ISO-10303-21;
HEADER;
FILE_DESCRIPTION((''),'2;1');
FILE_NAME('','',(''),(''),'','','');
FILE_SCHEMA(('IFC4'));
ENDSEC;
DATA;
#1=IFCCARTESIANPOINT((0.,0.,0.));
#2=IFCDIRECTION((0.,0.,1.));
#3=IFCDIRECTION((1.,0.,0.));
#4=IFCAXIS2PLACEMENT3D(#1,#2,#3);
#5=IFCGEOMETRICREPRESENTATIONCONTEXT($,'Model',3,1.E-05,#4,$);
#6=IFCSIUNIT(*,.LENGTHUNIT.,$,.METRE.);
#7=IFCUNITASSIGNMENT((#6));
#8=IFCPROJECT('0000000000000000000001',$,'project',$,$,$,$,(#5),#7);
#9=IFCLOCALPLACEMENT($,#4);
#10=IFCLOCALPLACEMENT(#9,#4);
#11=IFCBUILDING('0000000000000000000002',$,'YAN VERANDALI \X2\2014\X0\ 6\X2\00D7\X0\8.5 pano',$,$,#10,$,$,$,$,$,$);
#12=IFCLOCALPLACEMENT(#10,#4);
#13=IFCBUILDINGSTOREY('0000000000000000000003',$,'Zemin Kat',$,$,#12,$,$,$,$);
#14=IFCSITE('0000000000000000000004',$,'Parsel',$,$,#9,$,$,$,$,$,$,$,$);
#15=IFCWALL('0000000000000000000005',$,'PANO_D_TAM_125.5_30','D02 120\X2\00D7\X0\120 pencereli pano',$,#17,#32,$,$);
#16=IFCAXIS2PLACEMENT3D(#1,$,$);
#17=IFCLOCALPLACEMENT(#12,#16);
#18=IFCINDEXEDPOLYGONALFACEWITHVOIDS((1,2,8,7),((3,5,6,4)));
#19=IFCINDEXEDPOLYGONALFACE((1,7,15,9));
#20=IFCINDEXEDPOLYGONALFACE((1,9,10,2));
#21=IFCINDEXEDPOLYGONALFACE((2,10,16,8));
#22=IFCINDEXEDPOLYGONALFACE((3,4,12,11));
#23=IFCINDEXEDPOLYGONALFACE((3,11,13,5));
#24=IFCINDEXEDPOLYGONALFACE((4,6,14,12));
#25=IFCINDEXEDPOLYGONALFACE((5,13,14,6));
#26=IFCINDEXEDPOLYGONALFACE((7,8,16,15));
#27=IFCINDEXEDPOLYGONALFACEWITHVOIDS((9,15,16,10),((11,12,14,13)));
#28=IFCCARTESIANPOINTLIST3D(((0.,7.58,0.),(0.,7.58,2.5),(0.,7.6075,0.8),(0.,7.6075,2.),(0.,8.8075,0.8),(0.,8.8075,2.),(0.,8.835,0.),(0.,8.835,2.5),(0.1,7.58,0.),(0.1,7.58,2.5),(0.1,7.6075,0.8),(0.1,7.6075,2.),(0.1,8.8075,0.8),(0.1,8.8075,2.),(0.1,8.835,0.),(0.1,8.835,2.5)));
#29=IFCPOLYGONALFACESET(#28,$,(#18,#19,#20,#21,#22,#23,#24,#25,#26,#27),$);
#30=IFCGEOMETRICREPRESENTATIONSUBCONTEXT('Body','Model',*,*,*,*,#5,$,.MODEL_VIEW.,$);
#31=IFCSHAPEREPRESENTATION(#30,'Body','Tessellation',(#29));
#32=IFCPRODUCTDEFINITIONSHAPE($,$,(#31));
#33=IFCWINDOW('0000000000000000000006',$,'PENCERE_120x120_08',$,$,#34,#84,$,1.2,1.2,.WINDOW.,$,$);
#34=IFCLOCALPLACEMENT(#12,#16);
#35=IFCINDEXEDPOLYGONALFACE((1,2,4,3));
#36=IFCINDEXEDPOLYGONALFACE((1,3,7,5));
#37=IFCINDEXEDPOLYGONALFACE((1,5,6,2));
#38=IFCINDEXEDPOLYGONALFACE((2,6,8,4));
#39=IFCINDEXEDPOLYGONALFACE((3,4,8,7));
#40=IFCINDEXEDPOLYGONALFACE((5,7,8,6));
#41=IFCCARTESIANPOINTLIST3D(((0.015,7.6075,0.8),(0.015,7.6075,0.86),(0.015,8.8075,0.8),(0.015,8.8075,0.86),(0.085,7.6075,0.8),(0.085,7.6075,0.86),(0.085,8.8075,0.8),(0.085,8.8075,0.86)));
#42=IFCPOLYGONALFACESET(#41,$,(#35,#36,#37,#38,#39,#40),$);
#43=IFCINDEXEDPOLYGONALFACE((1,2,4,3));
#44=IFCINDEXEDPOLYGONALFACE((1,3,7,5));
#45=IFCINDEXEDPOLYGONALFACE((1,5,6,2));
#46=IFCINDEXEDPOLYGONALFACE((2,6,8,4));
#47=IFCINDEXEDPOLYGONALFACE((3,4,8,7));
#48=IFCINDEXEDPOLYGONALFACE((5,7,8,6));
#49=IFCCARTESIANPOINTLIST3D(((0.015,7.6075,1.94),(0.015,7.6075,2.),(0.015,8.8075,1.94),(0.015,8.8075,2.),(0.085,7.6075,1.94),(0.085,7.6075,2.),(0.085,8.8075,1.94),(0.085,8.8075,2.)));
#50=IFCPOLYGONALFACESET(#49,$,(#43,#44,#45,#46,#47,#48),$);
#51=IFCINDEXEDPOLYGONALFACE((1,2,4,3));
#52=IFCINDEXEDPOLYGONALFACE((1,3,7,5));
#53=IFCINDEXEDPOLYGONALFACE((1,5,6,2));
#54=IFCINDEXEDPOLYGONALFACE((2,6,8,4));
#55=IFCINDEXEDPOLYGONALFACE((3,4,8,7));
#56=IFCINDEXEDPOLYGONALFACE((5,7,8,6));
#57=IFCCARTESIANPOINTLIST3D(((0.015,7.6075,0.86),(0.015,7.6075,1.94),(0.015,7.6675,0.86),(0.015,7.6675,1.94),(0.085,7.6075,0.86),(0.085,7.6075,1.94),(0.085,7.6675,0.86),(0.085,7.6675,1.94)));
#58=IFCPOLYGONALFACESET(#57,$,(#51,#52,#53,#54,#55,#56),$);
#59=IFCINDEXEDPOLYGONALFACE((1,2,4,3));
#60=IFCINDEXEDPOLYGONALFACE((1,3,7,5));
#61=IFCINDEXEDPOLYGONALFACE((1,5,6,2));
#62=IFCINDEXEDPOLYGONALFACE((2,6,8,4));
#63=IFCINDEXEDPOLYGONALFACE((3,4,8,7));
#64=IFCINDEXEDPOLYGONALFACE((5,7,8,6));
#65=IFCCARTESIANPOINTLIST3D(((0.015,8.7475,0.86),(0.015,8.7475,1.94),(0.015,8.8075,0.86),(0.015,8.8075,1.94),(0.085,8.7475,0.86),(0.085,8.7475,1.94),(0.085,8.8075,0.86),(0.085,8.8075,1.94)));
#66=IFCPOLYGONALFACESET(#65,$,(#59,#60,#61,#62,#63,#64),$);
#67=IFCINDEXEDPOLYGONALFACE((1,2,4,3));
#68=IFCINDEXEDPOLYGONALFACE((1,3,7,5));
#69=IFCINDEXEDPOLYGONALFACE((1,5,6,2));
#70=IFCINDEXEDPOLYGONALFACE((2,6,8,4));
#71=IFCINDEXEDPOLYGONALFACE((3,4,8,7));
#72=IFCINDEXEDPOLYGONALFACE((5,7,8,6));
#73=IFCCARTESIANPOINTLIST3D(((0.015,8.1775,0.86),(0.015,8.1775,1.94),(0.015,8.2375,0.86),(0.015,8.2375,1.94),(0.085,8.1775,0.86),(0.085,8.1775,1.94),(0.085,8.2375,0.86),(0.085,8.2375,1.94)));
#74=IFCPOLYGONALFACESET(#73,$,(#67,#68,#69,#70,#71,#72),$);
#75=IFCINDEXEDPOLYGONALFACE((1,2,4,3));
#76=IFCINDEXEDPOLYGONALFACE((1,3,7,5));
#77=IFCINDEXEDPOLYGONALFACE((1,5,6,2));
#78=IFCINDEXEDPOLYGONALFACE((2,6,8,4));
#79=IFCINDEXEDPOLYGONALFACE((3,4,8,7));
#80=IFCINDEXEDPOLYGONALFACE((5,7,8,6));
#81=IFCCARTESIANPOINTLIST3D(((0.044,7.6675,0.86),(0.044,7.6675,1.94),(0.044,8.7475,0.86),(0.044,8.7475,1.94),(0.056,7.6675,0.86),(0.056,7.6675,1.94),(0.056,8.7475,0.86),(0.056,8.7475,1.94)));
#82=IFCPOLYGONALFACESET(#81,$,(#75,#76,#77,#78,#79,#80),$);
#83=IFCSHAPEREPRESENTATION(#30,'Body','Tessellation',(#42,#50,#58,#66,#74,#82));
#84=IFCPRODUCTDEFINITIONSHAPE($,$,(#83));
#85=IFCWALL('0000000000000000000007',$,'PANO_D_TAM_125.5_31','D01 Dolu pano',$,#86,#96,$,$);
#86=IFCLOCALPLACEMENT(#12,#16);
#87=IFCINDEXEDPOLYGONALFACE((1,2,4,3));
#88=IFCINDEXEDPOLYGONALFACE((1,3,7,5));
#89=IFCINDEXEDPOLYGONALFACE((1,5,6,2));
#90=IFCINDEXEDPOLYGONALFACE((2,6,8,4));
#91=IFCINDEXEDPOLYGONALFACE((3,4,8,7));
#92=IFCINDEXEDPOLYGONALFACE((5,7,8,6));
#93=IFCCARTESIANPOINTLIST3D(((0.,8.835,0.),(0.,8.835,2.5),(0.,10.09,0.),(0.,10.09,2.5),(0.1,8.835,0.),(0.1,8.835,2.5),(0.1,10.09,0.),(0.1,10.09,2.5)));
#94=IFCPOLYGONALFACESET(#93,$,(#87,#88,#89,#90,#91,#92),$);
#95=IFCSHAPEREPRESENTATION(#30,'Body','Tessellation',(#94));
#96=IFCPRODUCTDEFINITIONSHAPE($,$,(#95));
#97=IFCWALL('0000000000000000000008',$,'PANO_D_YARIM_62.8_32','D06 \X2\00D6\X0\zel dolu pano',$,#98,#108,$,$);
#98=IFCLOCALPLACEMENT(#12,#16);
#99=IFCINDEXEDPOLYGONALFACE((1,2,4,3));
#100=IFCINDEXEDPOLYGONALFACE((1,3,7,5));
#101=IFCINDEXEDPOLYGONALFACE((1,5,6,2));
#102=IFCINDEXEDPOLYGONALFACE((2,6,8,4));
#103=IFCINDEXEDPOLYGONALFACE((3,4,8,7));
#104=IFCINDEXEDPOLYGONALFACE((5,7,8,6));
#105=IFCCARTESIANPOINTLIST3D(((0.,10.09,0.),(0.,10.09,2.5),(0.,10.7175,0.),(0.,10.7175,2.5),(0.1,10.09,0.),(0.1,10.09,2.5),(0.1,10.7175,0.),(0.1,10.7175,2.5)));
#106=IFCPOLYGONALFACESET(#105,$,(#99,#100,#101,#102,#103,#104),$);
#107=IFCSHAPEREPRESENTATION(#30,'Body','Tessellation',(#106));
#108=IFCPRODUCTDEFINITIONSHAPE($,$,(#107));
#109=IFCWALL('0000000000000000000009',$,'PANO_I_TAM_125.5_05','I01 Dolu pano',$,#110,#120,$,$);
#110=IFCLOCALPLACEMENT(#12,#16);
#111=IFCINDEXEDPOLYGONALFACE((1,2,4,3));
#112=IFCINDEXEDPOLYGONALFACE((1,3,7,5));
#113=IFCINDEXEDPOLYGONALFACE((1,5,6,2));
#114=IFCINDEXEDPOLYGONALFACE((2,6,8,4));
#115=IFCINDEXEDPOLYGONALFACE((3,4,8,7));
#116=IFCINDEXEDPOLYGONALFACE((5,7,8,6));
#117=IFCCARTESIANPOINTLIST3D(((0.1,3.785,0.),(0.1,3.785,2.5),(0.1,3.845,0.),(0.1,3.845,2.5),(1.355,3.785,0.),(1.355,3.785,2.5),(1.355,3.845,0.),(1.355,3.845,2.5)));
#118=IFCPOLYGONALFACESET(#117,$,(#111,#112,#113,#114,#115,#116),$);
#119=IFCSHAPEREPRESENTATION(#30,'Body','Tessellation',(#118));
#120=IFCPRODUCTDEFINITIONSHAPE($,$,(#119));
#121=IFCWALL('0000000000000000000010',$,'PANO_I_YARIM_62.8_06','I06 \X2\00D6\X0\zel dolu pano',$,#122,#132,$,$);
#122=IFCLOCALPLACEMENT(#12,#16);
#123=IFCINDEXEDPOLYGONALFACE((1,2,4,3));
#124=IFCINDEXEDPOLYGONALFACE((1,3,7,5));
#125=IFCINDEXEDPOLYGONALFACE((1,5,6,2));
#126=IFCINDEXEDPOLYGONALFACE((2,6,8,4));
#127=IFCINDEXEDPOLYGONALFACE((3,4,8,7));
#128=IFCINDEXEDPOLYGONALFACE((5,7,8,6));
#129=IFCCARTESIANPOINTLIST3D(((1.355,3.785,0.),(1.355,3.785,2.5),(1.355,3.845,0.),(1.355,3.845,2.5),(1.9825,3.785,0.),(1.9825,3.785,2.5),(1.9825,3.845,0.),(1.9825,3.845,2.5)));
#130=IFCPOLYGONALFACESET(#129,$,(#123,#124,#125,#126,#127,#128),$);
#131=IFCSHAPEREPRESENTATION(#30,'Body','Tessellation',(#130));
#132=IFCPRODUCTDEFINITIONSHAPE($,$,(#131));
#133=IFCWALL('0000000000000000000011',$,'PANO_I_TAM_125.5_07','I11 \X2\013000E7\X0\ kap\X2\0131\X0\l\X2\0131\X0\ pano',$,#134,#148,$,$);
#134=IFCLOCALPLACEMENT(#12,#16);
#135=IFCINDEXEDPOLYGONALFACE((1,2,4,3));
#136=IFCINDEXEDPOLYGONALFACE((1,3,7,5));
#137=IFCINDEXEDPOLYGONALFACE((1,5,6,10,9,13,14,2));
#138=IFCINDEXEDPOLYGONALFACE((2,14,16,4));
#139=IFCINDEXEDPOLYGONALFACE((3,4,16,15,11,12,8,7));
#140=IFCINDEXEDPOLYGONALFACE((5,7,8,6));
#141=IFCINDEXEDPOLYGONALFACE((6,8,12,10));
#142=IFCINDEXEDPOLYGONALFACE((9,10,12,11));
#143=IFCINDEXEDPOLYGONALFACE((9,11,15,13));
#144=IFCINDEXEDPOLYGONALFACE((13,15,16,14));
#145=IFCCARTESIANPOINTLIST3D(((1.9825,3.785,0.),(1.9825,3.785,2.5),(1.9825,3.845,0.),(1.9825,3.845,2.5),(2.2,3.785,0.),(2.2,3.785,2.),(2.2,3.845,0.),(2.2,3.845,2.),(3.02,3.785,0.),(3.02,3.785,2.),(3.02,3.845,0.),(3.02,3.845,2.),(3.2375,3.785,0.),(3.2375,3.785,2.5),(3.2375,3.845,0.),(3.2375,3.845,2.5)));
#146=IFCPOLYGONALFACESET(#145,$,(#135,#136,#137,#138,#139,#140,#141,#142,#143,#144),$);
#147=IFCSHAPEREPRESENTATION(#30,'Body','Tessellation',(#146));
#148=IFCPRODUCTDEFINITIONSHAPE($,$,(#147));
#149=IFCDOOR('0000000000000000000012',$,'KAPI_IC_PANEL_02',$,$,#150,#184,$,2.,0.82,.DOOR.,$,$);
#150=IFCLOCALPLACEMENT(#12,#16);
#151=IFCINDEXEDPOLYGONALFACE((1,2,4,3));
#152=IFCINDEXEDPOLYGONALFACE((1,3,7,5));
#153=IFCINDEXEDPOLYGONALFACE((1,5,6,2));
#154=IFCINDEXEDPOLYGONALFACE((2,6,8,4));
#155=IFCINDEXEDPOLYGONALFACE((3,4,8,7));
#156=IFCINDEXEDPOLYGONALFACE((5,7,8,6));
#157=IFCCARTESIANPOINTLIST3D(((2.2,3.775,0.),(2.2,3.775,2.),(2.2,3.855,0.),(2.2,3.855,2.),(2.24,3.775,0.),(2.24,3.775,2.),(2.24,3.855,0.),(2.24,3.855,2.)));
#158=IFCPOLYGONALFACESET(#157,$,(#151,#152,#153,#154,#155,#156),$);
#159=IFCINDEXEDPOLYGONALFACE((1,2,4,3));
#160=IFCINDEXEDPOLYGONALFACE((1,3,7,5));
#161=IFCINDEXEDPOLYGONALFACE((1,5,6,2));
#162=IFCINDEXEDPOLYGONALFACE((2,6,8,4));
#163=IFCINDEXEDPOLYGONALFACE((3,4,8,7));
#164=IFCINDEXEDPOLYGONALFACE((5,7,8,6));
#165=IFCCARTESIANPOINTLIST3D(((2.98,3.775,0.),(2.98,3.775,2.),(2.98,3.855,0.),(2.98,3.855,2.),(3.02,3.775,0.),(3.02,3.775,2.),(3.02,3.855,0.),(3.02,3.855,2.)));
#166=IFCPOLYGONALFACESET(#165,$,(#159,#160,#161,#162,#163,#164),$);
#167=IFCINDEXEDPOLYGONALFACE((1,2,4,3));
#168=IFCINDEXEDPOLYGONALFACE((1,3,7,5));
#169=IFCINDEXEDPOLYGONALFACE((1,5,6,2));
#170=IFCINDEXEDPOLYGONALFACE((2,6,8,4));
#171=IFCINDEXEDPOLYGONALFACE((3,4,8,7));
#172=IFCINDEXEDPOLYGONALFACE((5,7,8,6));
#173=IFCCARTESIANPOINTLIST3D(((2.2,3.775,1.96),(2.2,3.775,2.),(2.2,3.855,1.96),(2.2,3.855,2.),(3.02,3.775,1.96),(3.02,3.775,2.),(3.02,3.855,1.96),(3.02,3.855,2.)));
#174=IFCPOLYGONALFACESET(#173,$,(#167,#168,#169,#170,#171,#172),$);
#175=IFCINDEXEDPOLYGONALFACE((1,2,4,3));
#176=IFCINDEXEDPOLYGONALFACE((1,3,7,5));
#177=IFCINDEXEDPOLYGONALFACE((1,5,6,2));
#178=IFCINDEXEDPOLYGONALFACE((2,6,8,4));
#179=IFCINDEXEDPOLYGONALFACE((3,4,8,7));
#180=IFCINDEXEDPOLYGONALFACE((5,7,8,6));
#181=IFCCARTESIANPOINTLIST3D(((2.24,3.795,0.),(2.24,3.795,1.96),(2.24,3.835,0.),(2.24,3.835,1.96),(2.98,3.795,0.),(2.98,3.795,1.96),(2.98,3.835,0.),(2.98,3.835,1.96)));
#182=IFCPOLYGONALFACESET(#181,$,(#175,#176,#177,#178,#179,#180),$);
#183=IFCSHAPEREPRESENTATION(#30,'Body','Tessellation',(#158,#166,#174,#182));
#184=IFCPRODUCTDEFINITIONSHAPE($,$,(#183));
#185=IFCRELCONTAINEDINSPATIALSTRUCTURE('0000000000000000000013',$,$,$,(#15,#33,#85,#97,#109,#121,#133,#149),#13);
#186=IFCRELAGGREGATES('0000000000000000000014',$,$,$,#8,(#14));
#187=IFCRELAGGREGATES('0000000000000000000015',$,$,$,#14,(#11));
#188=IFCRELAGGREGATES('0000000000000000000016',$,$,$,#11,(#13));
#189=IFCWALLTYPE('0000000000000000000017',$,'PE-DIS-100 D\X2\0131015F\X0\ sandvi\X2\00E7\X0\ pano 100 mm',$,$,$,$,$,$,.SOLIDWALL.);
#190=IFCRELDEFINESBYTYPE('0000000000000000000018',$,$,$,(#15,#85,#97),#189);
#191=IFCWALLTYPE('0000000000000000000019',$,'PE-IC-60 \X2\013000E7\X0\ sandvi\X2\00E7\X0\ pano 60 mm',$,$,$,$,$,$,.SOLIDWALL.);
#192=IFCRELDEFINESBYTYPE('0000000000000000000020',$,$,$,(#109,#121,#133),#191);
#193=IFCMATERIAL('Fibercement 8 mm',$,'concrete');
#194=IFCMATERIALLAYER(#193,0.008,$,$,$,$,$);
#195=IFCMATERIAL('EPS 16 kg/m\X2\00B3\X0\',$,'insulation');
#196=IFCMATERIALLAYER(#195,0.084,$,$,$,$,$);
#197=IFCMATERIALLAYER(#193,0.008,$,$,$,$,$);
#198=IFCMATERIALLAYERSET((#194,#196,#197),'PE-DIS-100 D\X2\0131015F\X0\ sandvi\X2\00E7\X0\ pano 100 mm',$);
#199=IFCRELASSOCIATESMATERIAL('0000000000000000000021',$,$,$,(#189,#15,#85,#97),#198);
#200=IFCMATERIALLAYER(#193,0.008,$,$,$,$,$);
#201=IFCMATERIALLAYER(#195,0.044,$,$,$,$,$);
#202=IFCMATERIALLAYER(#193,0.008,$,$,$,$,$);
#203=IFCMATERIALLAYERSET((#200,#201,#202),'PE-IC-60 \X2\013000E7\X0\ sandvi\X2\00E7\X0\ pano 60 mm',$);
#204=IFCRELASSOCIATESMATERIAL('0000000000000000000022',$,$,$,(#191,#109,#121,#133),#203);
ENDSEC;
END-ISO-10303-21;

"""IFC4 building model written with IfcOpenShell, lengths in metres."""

from ifc_helpers import new_model, si_unit, frame, origin_with_axes, place, context, subcontext, project, spatial, line, indexed_curve, outline, extrude, material, layer, layer_set, layer_usage, type_object, element, fill, save


model = new_model("IFC4")

# Units and contexts
model_context = context("Model", 3, precision=1e-05, world=origin_with_axes())
body_context = subcontext(model_context, "Body", "Model", "MODEL_VIEW")
ifc_project = project(units=[si_unit("LENGTHUNIT", "METRE")], contexts=[model_context])

# Site, building, storey
site_placement = place(None, origin_with_axes())
site = spatial("IfcSite", under=ifc_project, at=site_placement, Name="Parsel")
building_placement = place(site_placement, origin_with_axes())
building = spatial("IfcBuilding", under=site, at=building_placement, Name="YAN VERANDALI — 6×8.5 pano")
storey_placement = place(building_placement, origin_with_axes())
storey = spatial("IfcBuildingStorey", under=building, at=storey_placement, Name="Zemin Kat")

# Shared definitions
ifc_material_1 = material(Name="Fibercement 8 mm", Category="concrete")
ifc_layer_1 = layer(ifc_material_1, 0.008)
ifc_material_2 = material(Name="EPS 16 kg/m³", Category="insulation")
ifc_layer_2 = layer(ifc_material_2, 0.084)
ifc_layer_3 = layer(ifc_material_1, 0.008)
ifc_layer_set_1 = layer_set([ifc_layer_1, ifc_layer_2, ifc_layer_3], Name="PE-DIS-100 Dış sandviç pano 100 mm")
wall_type_1 = type_object("IfcWallType", Name="PE-DIS-100 Dış sandviç pano 100 mm", PredefinedType="SOLIDWALL", material=ifc_layer_set_1)

# Wall, opening, window
ifc_layer_usage_1 = layer_usage(ifc_layer_set_1, "AXIS2", "POSITIVE", 0.0)
wall_1_placement = place(storey_placement, frame((0.1, 7.58, 0.0), z_axis=(0.0, 0.0, 1.0), x_axis=(0.0, 1.0, 0.0)))
wall_1 = element("IfcWall", 1, at=wall_1_placement, inside=storey, type_object=wall_type_1, material=ifc_layer_usage_1, Name="PANO_D_TAM_125.5_30", Description="D02 120×120 pencereli pano", context=body_context, shape_type="SweptSolid", body=[
    extrude(outline(indexed_curve([(0.0, 0.0), (1.255, 0.0), (1.255, 0.1), (0.0, 0.1)], segments=[line(1, 2, 3, 4, 1)])), origin_with_axes(), (0.0, 0.0, 1.0), 2.5),
])
opening_1_placement = place(wall_1_placement, origin_with_axes())
opening_1 = element("IfcOpeningElement", 2, at=opening_1_placement, cuts=wall_1, PredefinedType="OPENING", context=body_context, shape_type="SweptSolid", body=[
    extrude(outline(indexed_curve([(0.0, 0.0), (1.2, 0.0), (1.2, 0.14), (0.0, 0.14)], segments=[line(1, 2, 3, 4, 1)])), frame((0.0275, -0.02, 0.8), z_axis=(0.0, 0.0, 1.0), x_axis=(1.0, 0.0, 0.0)), (0.0, 0.0, 1.0), 1.2),
])
window_1_placement = place(storey_placement, frame((0.1, 7.58, 0.0), z_axis=(0.0, 0.0, 1.0), x_axis=(0.0, 1.0, 0.0)))
window_1 = element("IfcWindow", 3, at=window_1_placement, inside=storey, Name="PENCERE_120x120_08", OverallHeight=1.2, OverallWidth=1.2, PredefinedType="WINDOW", context=body_context, shape_type="SweptSolid", body=[
    extrude(outline(indexed_curve([(0.0, 0.0), (1.2, 0.0), (1.2, 0.07), (0.0, 0.07)], segments=[line(1, 2, 3, 4, 1)])), frame((0.0275, 0.015, 0.8), z_axis=(0.0, 0.0, 1.0), x_axis=(1.0, 0.0, 0.0)), (0.0, 0.0, 1.0), 0.06),
    extrude(outline(indexed_curve([(0.0, 0.0), (1.2, 0.0), (1.2, 0.07), (0.0, 0.07)], segments=[line(1, 2, 3, 4, 1)])), frame((0.0275, 0.015, 1.94), z_axis=(0.0, 0.0, 1.0), x_axis=(1.0, 0.0, 0.0)), (0.0, 0.0, 1.0), 0.06),
    extrude(outline(indexed_curve([(0.0, 0.0), (0.06, 0.0), (0.06, 0.07), (0.0, 0.07)], segments=[line(1, 2, 3, 4, 1)])), frame((0.0275, 0.015, 0.86), z_axis=(0.0, 0.0, 1.0), x_axis=(1.0, 0.0, 0.0)), (0.0, 0.0, 1.0), 1.08),
    extrude(outline(indexed_curve([(0.0, 0.0), (0.06, 0.0), (0.06, 0.07), (0.0, 0.07)], segments=[line(1, 2, 3, 4, 1)])), frame((1.1675, 0.015, 0.86), z_axis=(0.0, 0.0, 1.0), x_axis=(1.0, 0.0, 0.0)), (0.0, 0.0, 1.0), 1.08),
    extrude(outline(indexed_curve([(0.0, 0.0), (0.06, 0.0), (0.06, 0.07), (0.0, 0.07)], segments=[line(1, 2, 3, 4, 1)])), frame((0.5975, 0.015, 0.86), z_axis=(0.0, 0.0, 1.0), x_axis=(1.0, 0.0, 0.0)), (0.0, 0.0, 1.0), 1.08),
    extrude(outline(indexed_curve([(0.0, 0.0), (1.08, 0.0), (1.08, 0.012), (0.0, 0.012)], segments=[line(1, 2, 3, 4, 1)])), frame((0.0875, 0.044, 0.86), z_axis=(0.0, 0.0, 1.0), x_axis=(1.0, 0.0, 0.0)), (0.0, 0.0, 1.0), 1.08),
])
fill(opening_1, window_1)

# Walls
ifc_layer_usage_2 = layer_usage(ifc_layer_set_1, "AXIS2", "POSITIVE", 0.0)
wall_2_placement = place(storey_placement, frame((0.1, 8.835, 0.0), z_axis=(0.0, 0.0, 1.0), x_axis=(0.0, 1.0, 0.0)))
element("IfcWall", 4, at=wall_2_placement, inside=storey, type_object=wall_type_1, material=ifc_layer_usage_2, Name="PANO_D_TAM_125.5_31", Description="D01 Dolu pano", context=body_context, shape_type="SweptSolid", body=[
    extrude(outline(indexed_curve([(0.0, 0.0), (1.255, 0.0), (1.255, 0.1), (0.0, 0.1)], segments=[line(1, 2, 3, 4, 1)])), origin_with_axes(), (0.0, 0.0, 1.0), 2.5),
])
ifc_layer_usage_3 = layer_usage(ifc_layer_set_1, "AXIS2", "POSITIVE", 0.0)
wall_3_placement = place(storey_placement, frame((0.1, 10.09, 0.0), z_axis=(0.0, 0.0, 1.0), x_axis=(0.0, 1.0, 0.0)))
element("IfcWall", 5, at=wall_3_placement, inside=storey, type_object=wall_type_1, material=ifc_layer_usage_3, Name="PANO_D_YARIM_62.8_32", Description="D06 Özel dolu pano", context=body_context, shape_type="SweptSolid", body=[
    extrude(outline(indexed_curve([(0.0, 0.0), (0.6275, 0.0), (0.6275, 0.1), (0.0, 0.1)], segments=[line(1, 2, 3, 4, 1)])), origin_with_axes(), (0.0, 0.0, 1.0), 2.5),
])
ifc_layer_4 = layer(ifc_material_1, 0.008)
ifc_layer_5 = layer(ifc_material_2, 0.044)
ifc_layer_6 = layer(ifc_material_1, 0.008)
ifc_layer_set_2 = layer_set([ifc_layer_4, ifc_layer_5, ifc_layer_6], Name="PE-IC-60 İç sandviç pano 60 mm")
ifc_layer_usage_4 = layer_usage(ifc_layer_set_2, "AXIS2", "POSITIVE", 0.0)
wall_type_2 = type_object("IfcWallType", Name="PE-IC-60 İç sandviç pano 60 mm", PredefinedType="SOLIDWALL", material=ifc_layer_set_2)
wall_4_placement = place(storey_placement, frame((0.1, 3.785, 0.0), z_axis=(0.0, 0.0, 1.0), x_axis=(1.0, 0.0, 0.0)))
element("IfcWall", 6, at=wall_4_placement, inside=storey, type_object=wall_type_2, material=ifc_layer_usage_4, Name="PANO_I_TAM_125.5_05", Description="I01 Dolu pano", context=body_context, shape_type="SweptSolid", body=[
    extrude(outline(indexed_curve([(0.0, 0.0), (1.255, 0.0), (1.255, 0.06), (0.0, 0.06)], segments=[line(1, 2, 3, 4, 1)])), origin_with_axes(), (0.0, 0.0, 1.0), 2.5),
])
ifc_layer_usage_5 = layer_usage(ifc_layer_set_2, "AXIS2", "POSITIVE", 0.0)
wall_5_placement = place(storey_placement, frame((1.355, 3.785, 0.0), z_axis=(0.0, 0.0, 1.0), x_axis=(1.0, 0.0, 0.0)))
element("IfcWall", 7, at=wall_5_placement, inside=storey, type_object=wall_type_2, material=ifc_layer_usage_5, Name="PANO_I_YARIM_62.8_06", Description="I06 Özel dolu pano", context=body_context, shape_type="SweptSolid", body=[
    extrude(outline(indexed_curve([(0.0, 0.0), (0.6275, 0.0), (0.6275, 0.06), (0.0, 0.06)], segments=[line(1, 2, 3, 4, 1)])), origin_with_axes(), (0.0, 0.0, 1.0), 2.5),
])

# Wall, opening, door
ifc_layer_usage_6 = layer_usage(ifc_layer_set_2, "AXIS2", "POSITIVE", 0.0)
wall_6_placement = place(storey_placement, frame((1.9825, 3.785, 0.0), z_axis=(0.0, 0.0, 1.0), x_axis=(1.0, 0.0, 0.0)))
wall_6 = element("IfcWall", 8, at=wall_6_placement, inside=storey, type_object=wall_type_2, material=ifc_layer_usage_6, Name="PANO_I_TAM_125.5_07", Description="I11 İç kapılı pano", context=body_context, shape_type="SweptSolid", body=[
    extrude(outline(indexed_curve([(0.0, 0.0), (1.255, 0.0), (1.255, 0.06), (0.0, 0.06)], segments=[line(1, 2, 3, 4, 1)])), origin_with_axes(), (0.0, 0.0, 1.0), 2.5),
])
opening_2_placement = place(wall_6_placement, origin_with_axes())
opening_2 = element("IfcOpeningElement", 9, at=opening_2_placement, cuts=wall_6, PredefinedType="OPENING", context=body_context, shape_type="SweptSolid", body=[
    extrude(outline(indexed_curve([(0.0, 0.0), (0.82, 0.0), (0.82, 0.1), (0.0, 0.1)], segments=[line(1, 2, 3, 4, 1)])), frame((0.2175, -0.02, 0.0), z_axis=(0.0, 0.0, 1.0), x_axis=(1.0, 0.0, 0.0)), (0.0, 0.0, 1.0), 2.0),
])
door_1_placement = place(storey_placement, frame((1.9825, 3.785, 0.0), z_axis=(0.0, 0.0, 1.0), x_axis=(1.0, 0.0, 0.0)))
door_1 = element("IfcDoor", 10, at=door_1_placement, inside=storey, Name="KAPI_IC_PANEL_02", OverallHeight=2.0, OverallWidth=0.82, PredefinedType="DOOR", context=body_context, shape_type="SweptSolid", body=[
    extrude(outline(indexed_curve([(0.0, 0.0), (0.04, 0.0), (0.04, 0.08), (0.0, 0.08)], segments=[line(1, 2, 3, 4, 1)])), frame((0.2175, -0.01, 0.0), z_axis=(0.0, 0.0, 1.0), x_axis=(1.0, 0.0, 0.0)), (0.0, 0.0, 1.0), 2.0),
    extrude(outline(indexed_curve([(0.0, 0.0), (0.04, 0.0), (0.04, 0.08), (0.0, 0.08)], segments=[line(1, 2, 3, 4, 1)])), frame((0.9975, -0.01, 0.0), z_axis=(0.0, 0.0, 1.0), x_axis=(1.0, 0.0, 0.0)), (0.0, 0.0, 1.0), 2.0),
    extrude(outline(indexed_curve([(0.0, 0.0), (0.82, 0.0), (0.82, 0.08), (0.0, 0.08)], segments=[line(1, 2, 3, 4, 1)])), frame((0.2175, -0.01, 1.96), z_axis=(0.0, 0.0, 1.0), x_axis=(1.0, 0.0, 0.0)), (0.0, 0.0, 1.0), 0.04),
    extrude(outline(indexed_curve([(0.0, 0.0), (0.74, 0.0), (0.74, 0.04), (0.0, 0.04)], segments=[line(1, 2, 3, 4, 1)])), frame((0.2575, 0.01, 0.0), z_axis=(0.0, 0.0, 1.0), x_axis=(1.0, 0.0, 0.0)), (0.0, 0.0, 1.0), 1.96),
])
fill(opening_2, door_1)

save(model, "model.ifc")
